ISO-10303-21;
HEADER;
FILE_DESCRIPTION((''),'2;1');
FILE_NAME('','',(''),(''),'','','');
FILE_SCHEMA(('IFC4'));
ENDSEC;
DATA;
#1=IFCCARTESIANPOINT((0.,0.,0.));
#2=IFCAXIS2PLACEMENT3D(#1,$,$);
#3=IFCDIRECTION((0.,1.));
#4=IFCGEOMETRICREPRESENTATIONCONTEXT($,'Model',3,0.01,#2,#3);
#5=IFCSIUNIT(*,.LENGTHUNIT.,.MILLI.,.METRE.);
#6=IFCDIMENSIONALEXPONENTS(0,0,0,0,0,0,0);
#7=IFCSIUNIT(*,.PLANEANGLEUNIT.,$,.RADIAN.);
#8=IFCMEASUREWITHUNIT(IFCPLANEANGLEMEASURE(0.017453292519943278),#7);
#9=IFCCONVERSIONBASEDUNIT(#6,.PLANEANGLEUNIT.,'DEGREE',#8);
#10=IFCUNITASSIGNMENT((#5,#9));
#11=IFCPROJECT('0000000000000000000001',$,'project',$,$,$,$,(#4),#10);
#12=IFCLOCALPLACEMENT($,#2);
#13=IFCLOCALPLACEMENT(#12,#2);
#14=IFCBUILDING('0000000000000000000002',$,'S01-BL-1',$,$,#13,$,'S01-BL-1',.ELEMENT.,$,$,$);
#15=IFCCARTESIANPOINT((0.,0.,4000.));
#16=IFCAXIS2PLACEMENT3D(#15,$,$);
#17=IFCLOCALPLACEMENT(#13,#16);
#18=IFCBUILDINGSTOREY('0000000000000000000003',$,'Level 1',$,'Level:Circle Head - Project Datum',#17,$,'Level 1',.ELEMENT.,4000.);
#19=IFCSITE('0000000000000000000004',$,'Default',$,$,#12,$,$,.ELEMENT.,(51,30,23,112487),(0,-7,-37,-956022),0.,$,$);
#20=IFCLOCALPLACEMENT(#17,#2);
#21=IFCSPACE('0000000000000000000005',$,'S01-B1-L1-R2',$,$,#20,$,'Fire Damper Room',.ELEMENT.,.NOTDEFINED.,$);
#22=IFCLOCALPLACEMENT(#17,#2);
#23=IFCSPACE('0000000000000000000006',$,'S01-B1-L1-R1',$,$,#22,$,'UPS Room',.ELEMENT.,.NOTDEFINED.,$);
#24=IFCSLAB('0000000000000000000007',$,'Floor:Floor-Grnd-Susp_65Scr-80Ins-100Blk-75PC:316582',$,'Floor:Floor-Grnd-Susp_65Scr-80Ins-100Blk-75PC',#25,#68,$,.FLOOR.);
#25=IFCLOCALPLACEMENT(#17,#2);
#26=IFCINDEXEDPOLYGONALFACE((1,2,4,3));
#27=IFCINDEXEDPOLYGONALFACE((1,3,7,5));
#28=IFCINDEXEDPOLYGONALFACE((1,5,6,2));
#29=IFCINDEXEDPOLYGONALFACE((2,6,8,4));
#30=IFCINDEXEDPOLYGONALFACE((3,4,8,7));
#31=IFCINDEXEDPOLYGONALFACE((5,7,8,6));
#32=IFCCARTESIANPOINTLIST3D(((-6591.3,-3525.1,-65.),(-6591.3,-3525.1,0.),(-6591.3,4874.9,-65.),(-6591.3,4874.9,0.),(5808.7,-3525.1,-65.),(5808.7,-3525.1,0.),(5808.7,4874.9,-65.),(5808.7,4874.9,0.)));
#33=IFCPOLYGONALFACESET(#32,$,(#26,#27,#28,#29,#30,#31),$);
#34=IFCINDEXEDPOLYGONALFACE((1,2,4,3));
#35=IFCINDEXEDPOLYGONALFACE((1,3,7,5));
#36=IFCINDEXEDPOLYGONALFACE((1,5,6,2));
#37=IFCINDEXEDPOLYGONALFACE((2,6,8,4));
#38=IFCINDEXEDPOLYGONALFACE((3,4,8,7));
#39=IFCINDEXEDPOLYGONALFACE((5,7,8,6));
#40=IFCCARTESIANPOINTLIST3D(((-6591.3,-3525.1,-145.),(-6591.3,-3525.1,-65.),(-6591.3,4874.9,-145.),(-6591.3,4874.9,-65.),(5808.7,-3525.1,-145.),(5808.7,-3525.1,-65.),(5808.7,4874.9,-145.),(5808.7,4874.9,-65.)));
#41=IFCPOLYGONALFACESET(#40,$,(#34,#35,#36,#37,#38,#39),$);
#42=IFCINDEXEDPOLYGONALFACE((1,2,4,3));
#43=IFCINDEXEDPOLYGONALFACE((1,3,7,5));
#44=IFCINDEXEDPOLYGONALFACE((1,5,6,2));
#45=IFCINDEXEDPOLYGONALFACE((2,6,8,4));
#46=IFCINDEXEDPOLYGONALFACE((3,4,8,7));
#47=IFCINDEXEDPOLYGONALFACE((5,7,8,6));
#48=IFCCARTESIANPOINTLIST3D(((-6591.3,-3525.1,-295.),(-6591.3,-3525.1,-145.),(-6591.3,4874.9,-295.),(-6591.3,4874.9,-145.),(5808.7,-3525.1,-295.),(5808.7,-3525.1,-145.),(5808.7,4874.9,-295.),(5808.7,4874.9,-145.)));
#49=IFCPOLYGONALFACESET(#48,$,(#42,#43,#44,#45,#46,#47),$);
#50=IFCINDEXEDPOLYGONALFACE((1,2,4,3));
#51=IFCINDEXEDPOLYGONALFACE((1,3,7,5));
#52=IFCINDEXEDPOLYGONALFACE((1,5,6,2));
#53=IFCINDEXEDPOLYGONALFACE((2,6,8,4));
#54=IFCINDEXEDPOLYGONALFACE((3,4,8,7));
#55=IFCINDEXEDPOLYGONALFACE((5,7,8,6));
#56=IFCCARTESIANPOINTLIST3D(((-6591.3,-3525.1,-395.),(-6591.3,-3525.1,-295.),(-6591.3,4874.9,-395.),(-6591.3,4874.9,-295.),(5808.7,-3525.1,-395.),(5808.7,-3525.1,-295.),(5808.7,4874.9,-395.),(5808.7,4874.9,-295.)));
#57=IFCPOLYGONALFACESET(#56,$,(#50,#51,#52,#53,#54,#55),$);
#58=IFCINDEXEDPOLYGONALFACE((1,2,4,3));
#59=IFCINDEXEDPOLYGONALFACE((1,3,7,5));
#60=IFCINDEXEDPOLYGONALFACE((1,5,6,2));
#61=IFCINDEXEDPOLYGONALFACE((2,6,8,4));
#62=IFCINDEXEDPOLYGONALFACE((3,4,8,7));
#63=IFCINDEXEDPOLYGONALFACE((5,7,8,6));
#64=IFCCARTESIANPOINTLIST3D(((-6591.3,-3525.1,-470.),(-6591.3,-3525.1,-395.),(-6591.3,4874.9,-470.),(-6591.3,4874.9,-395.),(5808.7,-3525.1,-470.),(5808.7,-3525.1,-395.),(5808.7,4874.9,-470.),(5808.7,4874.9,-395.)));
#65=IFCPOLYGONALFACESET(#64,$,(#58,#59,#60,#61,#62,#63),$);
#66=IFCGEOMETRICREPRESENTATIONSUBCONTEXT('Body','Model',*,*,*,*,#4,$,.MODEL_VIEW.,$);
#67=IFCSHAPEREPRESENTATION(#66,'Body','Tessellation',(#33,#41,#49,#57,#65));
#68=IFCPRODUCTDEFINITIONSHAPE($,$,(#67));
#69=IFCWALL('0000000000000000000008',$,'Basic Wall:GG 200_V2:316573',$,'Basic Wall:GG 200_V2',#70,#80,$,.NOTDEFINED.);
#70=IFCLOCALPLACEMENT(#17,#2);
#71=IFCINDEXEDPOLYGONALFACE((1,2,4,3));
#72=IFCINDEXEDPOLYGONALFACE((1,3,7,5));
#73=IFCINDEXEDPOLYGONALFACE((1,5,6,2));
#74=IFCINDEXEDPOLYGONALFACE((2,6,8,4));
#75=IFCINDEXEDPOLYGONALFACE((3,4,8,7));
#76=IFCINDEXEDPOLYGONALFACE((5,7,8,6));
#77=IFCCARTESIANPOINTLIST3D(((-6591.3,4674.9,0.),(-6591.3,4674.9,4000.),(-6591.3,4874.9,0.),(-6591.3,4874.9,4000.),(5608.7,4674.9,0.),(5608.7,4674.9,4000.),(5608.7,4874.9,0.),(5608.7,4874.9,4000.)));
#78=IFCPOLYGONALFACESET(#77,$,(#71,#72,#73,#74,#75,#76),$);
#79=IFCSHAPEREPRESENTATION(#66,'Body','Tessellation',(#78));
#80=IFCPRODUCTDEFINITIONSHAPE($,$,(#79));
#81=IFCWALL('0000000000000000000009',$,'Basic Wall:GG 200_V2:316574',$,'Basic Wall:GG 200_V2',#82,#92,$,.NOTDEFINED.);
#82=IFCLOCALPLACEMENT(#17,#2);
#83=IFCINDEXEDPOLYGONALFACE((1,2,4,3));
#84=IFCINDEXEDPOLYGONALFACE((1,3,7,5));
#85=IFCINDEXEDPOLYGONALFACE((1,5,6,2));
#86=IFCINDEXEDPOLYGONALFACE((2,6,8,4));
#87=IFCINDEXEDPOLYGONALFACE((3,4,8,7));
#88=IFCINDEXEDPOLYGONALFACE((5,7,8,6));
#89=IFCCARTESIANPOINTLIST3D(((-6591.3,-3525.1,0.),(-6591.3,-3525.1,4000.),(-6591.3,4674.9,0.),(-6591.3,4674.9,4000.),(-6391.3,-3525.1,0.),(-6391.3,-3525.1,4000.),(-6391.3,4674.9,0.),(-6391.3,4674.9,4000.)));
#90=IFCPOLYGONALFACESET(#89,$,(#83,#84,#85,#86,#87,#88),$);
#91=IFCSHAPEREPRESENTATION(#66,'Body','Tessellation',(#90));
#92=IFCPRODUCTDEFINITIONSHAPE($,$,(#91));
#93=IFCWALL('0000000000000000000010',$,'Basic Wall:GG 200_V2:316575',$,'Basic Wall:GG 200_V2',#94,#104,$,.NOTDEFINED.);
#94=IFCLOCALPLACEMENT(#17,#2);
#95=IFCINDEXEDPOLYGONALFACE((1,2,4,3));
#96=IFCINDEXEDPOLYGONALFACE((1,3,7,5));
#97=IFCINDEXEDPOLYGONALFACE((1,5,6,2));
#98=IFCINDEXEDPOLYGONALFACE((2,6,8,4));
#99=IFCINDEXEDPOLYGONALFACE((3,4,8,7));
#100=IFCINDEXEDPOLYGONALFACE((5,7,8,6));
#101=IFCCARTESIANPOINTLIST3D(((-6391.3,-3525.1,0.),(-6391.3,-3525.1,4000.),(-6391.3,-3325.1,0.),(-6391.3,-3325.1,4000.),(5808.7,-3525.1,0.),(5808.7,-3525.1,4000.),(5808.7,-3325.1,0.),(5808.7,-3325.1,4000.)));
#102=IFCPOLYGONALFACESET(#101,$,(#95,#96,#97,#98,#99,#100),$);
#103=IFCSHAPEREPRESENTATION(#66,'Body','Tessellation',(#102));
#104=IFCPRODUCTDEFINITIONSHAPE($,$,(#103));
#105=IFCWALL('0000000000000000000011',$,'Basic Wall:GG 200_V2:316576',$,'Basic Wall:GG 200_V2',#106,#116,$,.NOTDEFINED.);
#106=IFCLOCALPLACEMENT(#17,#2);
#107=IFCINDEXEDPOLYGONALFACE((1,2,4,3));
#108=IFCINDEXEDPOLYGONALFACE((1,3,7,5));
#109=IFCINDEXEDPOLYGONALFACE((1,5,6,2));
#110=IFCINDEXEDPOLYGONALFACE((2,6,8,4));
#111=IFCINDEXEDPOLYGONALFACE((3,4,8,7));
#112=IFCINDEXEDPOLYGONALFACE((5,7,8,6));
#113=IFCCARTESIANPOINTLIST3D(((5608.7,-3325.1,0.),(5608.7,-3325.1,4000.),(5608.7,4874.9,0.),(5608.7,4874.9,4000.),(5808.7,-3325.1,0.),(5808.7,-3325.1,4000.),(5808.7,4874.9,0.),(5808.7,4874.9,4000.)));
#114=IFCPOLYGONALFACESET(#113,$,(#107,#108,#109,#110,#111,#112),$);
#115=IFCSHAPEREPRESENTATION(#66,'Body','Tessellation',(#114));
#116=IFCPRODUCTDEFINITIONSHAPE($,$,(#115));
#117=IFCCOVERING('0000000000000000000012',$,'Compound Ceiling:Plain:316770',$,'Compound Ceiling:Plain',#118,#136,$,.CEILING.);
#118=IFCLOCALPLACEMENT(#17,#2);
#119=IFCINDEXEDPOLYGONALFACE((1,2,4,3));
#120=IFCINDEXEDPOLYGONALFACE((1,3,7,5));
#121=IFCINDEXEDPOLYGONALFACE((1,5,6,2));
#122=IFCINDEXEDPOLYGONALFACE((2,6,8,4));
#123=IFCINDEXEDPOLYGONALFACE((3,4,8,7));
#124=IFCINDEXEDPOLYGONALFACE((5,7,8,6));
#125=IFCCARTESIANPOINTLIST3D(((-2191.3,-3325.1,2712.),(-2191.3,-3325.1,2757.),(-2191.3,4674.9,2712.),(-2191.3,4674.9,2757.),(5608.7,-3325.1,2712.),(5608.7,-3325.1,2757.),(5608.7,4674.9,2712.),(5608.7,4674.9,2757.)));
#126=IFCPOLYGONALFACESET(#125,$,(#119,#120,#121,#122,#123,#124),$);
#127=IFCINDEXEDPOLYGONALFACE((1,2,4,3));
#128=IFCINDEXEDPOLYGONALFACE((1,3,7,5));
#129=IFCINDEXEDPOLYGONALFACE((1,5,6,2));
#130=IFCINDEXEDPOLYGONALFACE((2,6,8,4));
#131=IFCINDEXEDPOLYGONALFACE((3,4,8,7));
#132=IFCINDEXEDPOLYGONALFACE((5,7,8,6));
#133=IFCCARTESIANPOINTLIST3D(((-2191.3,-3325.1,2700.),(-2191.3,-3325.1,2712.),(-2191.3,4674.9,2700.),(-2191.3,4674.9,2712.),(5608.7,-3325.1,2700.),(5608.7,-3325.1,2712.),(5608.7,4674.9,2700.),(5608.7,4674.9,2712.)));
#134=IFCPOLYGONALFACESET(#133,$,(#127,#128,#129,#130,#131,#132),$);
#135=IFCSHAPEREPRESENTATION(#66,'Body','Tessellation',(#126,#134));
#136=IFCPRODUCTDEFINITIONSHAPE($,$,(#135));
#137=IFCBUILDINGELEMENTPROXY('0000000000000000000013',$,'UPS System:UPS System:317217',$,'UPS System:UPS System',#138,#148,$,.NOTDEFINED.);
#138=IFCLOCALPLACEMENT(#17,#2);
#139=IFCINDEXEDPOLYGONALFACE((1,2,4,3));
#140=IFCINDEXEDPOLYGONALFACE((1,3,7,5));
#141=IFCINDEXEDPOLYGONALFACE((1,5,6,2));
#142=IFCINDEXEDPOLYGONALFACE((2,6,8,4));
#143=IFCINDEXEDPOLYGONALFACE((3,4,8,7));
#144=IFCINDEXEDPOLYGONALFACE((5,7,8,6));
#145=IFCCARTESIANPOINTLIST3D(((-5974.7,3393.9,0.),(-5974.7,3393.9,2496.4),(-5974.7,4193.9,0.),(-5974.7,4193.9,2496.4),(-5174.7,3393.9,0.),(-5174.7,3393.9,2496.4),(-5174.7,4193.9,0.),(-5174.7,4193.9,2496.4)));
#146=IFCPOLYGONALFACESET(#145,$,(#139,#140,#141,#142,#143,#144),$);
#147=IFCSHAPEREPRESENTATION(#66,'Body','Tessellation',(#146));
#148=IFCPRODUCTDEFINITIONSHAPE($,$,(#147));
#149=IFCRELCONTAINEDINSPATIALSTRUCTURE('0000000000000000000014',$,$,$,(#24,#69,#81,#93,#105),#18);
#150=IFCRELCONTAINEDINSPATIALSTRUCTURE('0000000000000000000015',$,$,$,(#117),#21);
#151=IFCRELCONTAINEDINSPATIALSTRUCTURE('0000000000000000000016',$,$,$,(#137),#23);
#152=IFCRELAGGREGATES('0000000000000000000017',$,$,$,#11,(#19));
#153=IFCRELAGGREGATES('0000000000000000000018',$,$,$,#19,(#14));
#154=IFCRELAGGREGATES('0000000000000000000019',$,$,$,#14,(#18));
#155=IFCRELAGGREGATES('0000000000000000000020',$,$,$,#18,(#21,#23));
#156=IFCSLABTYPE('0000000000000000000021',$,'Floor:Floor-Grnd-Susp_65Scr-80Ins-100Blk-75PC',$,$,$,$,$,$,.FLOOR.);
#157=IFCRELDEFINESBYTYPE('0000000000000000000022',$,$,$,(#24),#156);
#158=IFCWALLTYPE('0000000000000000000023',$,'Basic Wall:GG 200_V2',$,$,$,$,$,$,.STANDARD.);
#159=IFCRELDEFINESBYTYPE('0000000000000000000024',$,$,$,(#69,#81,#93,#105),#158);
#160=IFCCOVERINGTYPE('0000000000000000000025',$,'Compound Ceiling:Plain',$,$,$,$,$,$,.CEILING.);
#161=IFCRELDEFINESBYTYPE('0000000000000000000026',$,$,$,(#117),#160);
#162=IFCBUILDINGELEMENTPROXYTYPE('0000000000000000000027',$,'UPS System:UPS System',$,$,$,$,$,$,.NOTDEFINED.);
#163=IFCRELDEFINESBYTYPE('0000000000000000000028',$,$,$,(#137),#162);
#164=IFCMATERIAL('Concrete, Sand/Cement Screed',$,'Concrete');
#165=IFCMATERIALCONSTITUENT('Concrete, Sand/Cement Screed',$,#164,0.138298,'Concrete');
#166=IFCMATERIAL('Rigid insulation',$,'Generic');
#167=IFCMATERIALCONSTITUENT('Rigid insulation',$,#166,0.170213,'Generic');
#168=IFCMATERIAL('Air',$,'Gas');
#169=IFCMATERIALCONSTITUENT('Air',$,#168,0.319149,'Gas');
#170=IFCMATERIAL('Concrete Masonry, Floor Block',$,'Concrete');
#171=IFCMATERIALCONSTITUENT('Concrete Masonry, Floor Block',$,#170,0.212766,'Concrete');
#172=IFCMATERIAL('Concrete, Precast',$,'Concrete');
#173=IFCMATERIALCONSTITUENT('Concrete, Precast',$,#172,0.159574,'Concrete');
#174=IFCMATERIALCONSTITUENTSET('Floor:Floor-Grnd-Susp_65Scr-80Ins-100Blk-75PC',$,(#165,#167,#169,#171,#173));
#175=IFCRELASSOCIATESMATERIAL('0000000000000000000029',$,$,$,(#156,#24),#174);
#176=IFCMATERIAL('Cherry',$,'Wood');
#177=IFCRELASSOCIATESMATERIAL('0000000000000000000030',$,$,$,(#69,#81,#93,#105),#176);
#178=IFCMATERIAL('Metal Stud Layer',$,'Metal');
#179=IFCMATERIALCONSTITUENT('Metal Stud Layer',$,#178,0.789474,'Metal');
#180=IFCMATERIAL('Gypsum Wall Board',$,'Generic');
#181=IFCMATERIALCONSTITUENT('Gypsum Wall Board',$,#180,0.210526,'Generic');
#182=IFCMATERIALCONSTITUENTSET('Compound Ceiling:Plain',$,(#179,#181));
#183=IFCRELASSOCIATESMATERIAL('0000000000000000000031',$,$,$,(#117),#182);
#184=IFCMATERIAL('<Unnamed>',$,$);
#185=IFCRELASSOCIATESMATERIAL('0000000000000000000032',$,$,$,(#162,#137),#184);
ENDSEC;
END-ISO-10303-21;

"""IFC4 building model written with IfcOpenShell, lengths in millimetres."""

from ifc_helpers import new_model, entity, si_unit, converted_unit, direction, frame, origin, place, context, subcontext, project, spatial, indexed_curve, outline, extrude, source, transform, mapped, material, constituent, constituent_set, type_object, type_shapes, element, save


model = new_model("IFC4")

# Units and contexts
model_context = context("Model", 3, precision=0.01, world=origin(), true_north=direction((0.0, 1.0)))
body_context = subcontext(model_context, "Body", "Model", "MODEL_VIEW")
ifc_project = project(units=[si_unit("LENGTHUNIT", "METRE", prefix="MILLI"), converted_unit("PLANEANGLEUNIT", "DEGREE", entity("IfcPlaneAngleMeasure", 0.017453292519943278), si_unit("PLANEANGLEUNIT", "RADIAN"), dimensions=[0, 0, 0, 0, 0, 0, 0])], contexts=[model_context])

# Site, building, storey
site_placement = place(None, origin())
site = spatial("IfcSite", under=ifc_project, at=site_placement, Name="Default", CompositionType="ELEMENT", RefLatitude=(51, 30, 23, 112487), RefLongitude=(0, -7, -37, -956022), RefElevation=0.0)
building_placement = place(site_placement, origin())
building = spatial("IfcBuilding", under=site, at=building_placement, Name="S01-BL-1", LongName="S01-BL-1", CompositionType="ELEMENT")
storey_placement = place(building_placement, frame((0.0, 0.0, 4000.0)))
storey = spatial("IfcBuildingStorey", under=building, at=storey_placement, Name="Level 1", ObjectType="Level:Circle Head - Project Datum", LongName="Level 1", CompositionType="ELEMENT", Elevation=4000.0)

# Slab
ifc_material_1 = material(Name="Concrete, Sand/Cement Screed", Category="Concrete")
ifc_constituent_1 = constituent(ifc_material_1, Name="Concrete, Sand/Cement Screed", Category="Concrete", fraction=0.138298)
ifc_material_2 = material(Name="Rigid insulation", Category="Generic")
ifc_constituent_2 = constituent(ifc_material_2, Name="Rigid insulation", Category="Generic", fraction=0.170213)
ifc_material_3 = material(Name="Air", Category="Gas")
ifc_constituent_3 = constituent(ifc_material_3, Name="Air", Category="Gas", fraction=0.319149)
ifc_material_4 = material(Name="Concrete Masonry, Floor Block", Category="Concrete")
ifc_constituent_4 = constituent(ifc_material_4, Name="Concrete Masonry, Floor Block", Category="Concrete", fraction=0.212766)
ifc_material_5 = material(Name="Concrete, Precast", Category="Concrete")
ifc_constituent_5 = constituent(ifc_material_5, Name="Concrete, Precast", Category="Concrete", fraction=0.159574)
ifc_constituent_set_1 = constituent_set(constituents=[ifc_constituent_1, ifc_constituent_2, ifc_constituent_3, ifc_constituent_4, ifc_constituent_5], Name="Floor:Floor-Grnd-Susp_65Scr-80Ins-100Blk-75PC")
slab_type = type_object("IfcSlabType", Name="Floor:Floor-Grnd-Susp_65Scr-80Ins-100Blk-75PC", PredefinedType="FLOOR", material=ifc_constituent_set_1)
slab_placement = place(storey_placement, origin())
element("IfcSlab", 1, at=slab_placement, inside=storey, type_object=slab_type, material=ifc_constituent_set_1, Name="Floor:Floor-Grnd-Susp_65Scr-80Ins-100Blk-75PC:316582", ObjectType="Floor:Floor-Grnd-Susp_65Scr-80Ins-100Blk-75PC", PredefinedType="FLOOR", context=body_context, shape_type="SweptSolid", body=[
    extrude(outline(indexed_curve([(-6200.0, -4200.0), (6200.0, -4200.0), (6200.0, 4200.0), (-6200.0, 4200.0), (-6200.0, -4200.0)], self_intersect=False)), frame((-391.3, 674.9, -65.0), z_axis=(0.0, 0.0, 1.0), x_axis=(-1.0, 0.0, 0.0)), (0.0, 0.0, 1.0), 65.0),
    extrude(outline(indexed_curve([(-6200.0, -4200.0), (6200.0, -4200.0), (6200.0, 4200.0), (-6200.0, 4200.0), (-6200.0, -4200.0)], self_intersect=False)), frame((-391.3, 674.9, -145.0), z_axis=(0.0, 0.0, 1.0), x_axis=(-1.0, 0.0, 0.0)), (0.0, 0.0, 1.0), 80.0),
    extrude(outline(indexed_curve([(-6200.0, -4200.0), (6200.0, -4200.0), (6200.0, 4200.0), (-6200.0, 4200.0), (-6200.0, -4200.0)], self_intersect=False)), frame((-391.3, 674.9, -295.0), z_axis=(0.0, 0.0, 1.0), x_axis=(-1.0, 0.0, 0.0)), (0.0, 0.0, 1.0), 150.0),
    extrude(outline(indexed_curve([(-6200.0, -4200.0), (6200.0, -4200.0), (6200.0, 4200.0), (-6200.0, 4200.0), (-6200.0, -4200.0)], self_intersect=False)), frame((-391.3, 674.9, -395.0), z_axis=(0.0, 0.0, 1.0), x_axis=(-1.0, 0.0, 0.0)), (0.0, 0.0, 1.0), 100.0),
    extrude(outline(indexed_curve([(-6200.0, -4200.0), (6200.0, -4200.0), (6200.0, 4200.0), (-6200.0, 4200.0), (-6200.0, -4200.0)], self_intersect=False)), frame((-391.3, 674.9, -470.0), z_axis=(0.0, 0.0, 1.0), x_axis=(-1.0, 0.0, 0.0)), (0.0, 0.0, 1.0), 75.0),
])

# Walls
ifc_material_6 = material(Name="Cherry", Category="Wood")
wall_type = type_object("IfcWallType", Name="Basic Wall:GG 200_V2", PredefinedType="STANDARD")
wall_1_placement = place(storey_placement, frame((-6591.3, 4774.9, 0.0)))
element("IfcWall", 2, at=wall_1_placement, inside=storey, type_object=wall_type, material=ifc_material_6, Name="Basic Wall:GG 200_V2:316573", ObjectType="Basic Wall:GG 200_V2", PredefinedType="NOTDEFINED", context=body_context, shape_type="SweptSolid", body=[
    extrude(outline(indexed_curve([(12200.0, 100.0), (0.0, 100.0), (0.0, -100.0), (12200.0, -100.0), (12200.0, 100.0)], self_intersect=False)), origin(), (0.0, 0.0, 1.0), 4000.0),
])
wall_2_placement = place(storey_placement, frame((-6491.3, -3525.1, 0.0), z_axis=(0.0, 0.0, 1.0), x_axis=(0.0, 1.0, 0.0)))
element("IfcWall", 3, at=wall_2_placement, inside=storey, type_object=wall_type, material=ifc_material_6, Name="Basic Wall:GG 200_V2:316574", ObjectType="Basic Wall:GG 200_V2", PredefinedType="NOTDEFINED", context=body_context, shape_type="SweptSolid", body=[
    extrude(outline(indexed_curve([(8200.0, 100.0), (0.0, 100.0), (0.0, -100.0), (8200.0, -100.0), (8200.0, 100.0)], self_intersect=False)), origin(), (0.0, 0.0, 1.0), 4000.0),
])
wall_3_placement = place(storey_placement, frame((5808.7, -3425.1, 0.0), z_axis=(0.0, 0.0, 1.0), x_axis=(-1.0, 0.0, 0.0)))
element("IfcWall", 4, at=wall_3_placement, inside=storey, type_object=wall_type, material=ifc_material_6, Name="Basic Wall:GG 200_V2:316575", ObjectType="Basic Wall:GG 200_V2", PredefinedType="NOTDEFINED", context=body_context, shape_type="SweptSolid", body=[
    extrude(outline(indexed_curve([(12200.0, 100.0), (0.0, 100.0), (0.0, -100.0), (12200.0, -100.0), (12200.0, 100.0)], self_intersect=False)), origin(), (0.0, 0.0, 1.0), 4000.0),
])
wall_4_placement = place(storey_placement, frame((5708.7, 4874.9, 0.0), z_axis=(0.0, 0.0, 1.0), x_axis=(0.0, -1.0, 0.0)))
element("IfcWall", 5, at=wall_4_placement, inside=storey, type_object=wall_type, material=ifc_material_6, Name="Basic Wall:GG 200_V2:316576", ObjectType="Basic Wall:GG 200_V2", PredefinedType="NOTDEFINED", context=body_context, shape_type="SweptSolid", body=[
    extrude(outline(indexed_curve([(8200.0, 100.0), (0.0, 100.0), (0.0, -100.0), (8200.0, -100.0), (8200.0, 100.0)], self_intersect=False)), origin(), (0.0, 0.0, 1.0), 4000.0),
])

# Shared definitions
space_1_placement = place(storey_placement, origin())
space_1 = spatial("IfcSpace", under=storey, at=space_1_placement, Name="S01-B1-L1-R2", LongName="Fire Damper Room", CompositionType="ELEMENT", PredefinedType="NOTDEFINED")

# Covering
ifc_material_7 = material(Name="Metal Stud Layer", Category="Metal")
ifc_constituent_6 = constituent(ifc_material_7, Name="Metal Stud Layer", Category="Metal", fraction=0.789474)
ifc_material_8 = material(Name="Gypsum Wall Board", Category="Generic")
ifc_constituent_7 = constituent(ifc_material_8, Name="Gypsum Wall Board", Category="Generic", fraction=0.210526)
ifc_constituent_set_2 = constituent_set(constituents=[ifc_constituent_6, ifc_constituent_7], Name="Compound Ceiling:Plain")
covering_type = type_object("IfcCoveringType", Name="Compound Ceiling:Plain", PredefinedType="CEILING")
covering_placement = place(space_1_placement, origin())
element("IfcCovering", 6, at=covering_placement, inside=space_1, type_object=covering_type, material=ifc_constituent_set_2, Name="Compound Ceiling:Plain:316770", ObjectType="Compound Ceiling:Plain", PredefinedType="CEILING", context=body_context, shape_type="SweptSolid", body=[
    extrude(outline(indexed_curve([(-4000.0, -3900.0), (4000.0, -3900.0), (4000.0, 3900.0), (-4000.0, 3900.0), (-4000.0, -3900.0)], self_intersect=False)), frame((1708.7, 674.9, 2712.0), z_axis=(0.0, 0.0, 1.0), x_axis=(0.0, 1.0, 0.0)), (0.0, 0.0, 1.0), 45.0),
    extrude(outline(indexed_curve([(-3900.0, -4000.0), (3900.0, -4000.0), (3900.0, 4000.0), (-3900.0, 4000.0), (-3900.0, -4000.0)], self_intersect=False)), frame((1708.7, 674.9, 2700.0)), (0.0, 0.0, 1.0), 12.0),
])

# Shared definitions
space_2_placement = place(storey_placement, origin())
space_2 = spatial("IfcSpace", under=storey, at=space_2_placement, Name="S01-B1-L1-R1", LongName="UPS Room", CompositionType="ELEMENT", PredefinedType="NOTDEFINED")

# Building element proxy
ifc_material_9 = material(Name="<Unnamed>")
building_element_proxy_type_1 = type_object("IfcBuildingElementProxyType", Name="UPS System:UPS System", PredefinedType="NOTDEFINED", material=ifc_material_9)
shared_shape_1 = source(origin(), body_context, "Body", "SweptSolid", [
    extrude(outline(indexed_curve([(-400.0, -400.0), (400.0, -400.0), (400.0, 400.0), (-400.0, 400.0), (-400.0, -400.0)], self_intersect=False)), frame((-5574.7, 3793.9, 4000.0), z_axis=(0.0, 0.0, 1.0), x_axis=(-1.0, 0.0, 0.0)), (0.0, 0.0, 1.0), 2496.4),
])
type_shapes(building_element_proxy_type_1, [shared_shape_1])
proxy_1_placement = place(space_2_placement, frame((0.0, 0.0, -4000.0)))
element("IfcBuildingElementProxy", 7, at=proxy_1_placement, inside=space_2, type_object=building_element_proxy_type_1, material=ifc_material_9, Name="UPS System:UPS System:317217", ObjectType="UPS System:UPS System", PredefinedType="NOTDEFINED", context=body_context, shape_type="MappedRepresentation", body=[
    mapped(shared_shape_1, transform((0.0, 0.0, 0.0), scale=1.0)),
])

save(model, "model.ifc")
